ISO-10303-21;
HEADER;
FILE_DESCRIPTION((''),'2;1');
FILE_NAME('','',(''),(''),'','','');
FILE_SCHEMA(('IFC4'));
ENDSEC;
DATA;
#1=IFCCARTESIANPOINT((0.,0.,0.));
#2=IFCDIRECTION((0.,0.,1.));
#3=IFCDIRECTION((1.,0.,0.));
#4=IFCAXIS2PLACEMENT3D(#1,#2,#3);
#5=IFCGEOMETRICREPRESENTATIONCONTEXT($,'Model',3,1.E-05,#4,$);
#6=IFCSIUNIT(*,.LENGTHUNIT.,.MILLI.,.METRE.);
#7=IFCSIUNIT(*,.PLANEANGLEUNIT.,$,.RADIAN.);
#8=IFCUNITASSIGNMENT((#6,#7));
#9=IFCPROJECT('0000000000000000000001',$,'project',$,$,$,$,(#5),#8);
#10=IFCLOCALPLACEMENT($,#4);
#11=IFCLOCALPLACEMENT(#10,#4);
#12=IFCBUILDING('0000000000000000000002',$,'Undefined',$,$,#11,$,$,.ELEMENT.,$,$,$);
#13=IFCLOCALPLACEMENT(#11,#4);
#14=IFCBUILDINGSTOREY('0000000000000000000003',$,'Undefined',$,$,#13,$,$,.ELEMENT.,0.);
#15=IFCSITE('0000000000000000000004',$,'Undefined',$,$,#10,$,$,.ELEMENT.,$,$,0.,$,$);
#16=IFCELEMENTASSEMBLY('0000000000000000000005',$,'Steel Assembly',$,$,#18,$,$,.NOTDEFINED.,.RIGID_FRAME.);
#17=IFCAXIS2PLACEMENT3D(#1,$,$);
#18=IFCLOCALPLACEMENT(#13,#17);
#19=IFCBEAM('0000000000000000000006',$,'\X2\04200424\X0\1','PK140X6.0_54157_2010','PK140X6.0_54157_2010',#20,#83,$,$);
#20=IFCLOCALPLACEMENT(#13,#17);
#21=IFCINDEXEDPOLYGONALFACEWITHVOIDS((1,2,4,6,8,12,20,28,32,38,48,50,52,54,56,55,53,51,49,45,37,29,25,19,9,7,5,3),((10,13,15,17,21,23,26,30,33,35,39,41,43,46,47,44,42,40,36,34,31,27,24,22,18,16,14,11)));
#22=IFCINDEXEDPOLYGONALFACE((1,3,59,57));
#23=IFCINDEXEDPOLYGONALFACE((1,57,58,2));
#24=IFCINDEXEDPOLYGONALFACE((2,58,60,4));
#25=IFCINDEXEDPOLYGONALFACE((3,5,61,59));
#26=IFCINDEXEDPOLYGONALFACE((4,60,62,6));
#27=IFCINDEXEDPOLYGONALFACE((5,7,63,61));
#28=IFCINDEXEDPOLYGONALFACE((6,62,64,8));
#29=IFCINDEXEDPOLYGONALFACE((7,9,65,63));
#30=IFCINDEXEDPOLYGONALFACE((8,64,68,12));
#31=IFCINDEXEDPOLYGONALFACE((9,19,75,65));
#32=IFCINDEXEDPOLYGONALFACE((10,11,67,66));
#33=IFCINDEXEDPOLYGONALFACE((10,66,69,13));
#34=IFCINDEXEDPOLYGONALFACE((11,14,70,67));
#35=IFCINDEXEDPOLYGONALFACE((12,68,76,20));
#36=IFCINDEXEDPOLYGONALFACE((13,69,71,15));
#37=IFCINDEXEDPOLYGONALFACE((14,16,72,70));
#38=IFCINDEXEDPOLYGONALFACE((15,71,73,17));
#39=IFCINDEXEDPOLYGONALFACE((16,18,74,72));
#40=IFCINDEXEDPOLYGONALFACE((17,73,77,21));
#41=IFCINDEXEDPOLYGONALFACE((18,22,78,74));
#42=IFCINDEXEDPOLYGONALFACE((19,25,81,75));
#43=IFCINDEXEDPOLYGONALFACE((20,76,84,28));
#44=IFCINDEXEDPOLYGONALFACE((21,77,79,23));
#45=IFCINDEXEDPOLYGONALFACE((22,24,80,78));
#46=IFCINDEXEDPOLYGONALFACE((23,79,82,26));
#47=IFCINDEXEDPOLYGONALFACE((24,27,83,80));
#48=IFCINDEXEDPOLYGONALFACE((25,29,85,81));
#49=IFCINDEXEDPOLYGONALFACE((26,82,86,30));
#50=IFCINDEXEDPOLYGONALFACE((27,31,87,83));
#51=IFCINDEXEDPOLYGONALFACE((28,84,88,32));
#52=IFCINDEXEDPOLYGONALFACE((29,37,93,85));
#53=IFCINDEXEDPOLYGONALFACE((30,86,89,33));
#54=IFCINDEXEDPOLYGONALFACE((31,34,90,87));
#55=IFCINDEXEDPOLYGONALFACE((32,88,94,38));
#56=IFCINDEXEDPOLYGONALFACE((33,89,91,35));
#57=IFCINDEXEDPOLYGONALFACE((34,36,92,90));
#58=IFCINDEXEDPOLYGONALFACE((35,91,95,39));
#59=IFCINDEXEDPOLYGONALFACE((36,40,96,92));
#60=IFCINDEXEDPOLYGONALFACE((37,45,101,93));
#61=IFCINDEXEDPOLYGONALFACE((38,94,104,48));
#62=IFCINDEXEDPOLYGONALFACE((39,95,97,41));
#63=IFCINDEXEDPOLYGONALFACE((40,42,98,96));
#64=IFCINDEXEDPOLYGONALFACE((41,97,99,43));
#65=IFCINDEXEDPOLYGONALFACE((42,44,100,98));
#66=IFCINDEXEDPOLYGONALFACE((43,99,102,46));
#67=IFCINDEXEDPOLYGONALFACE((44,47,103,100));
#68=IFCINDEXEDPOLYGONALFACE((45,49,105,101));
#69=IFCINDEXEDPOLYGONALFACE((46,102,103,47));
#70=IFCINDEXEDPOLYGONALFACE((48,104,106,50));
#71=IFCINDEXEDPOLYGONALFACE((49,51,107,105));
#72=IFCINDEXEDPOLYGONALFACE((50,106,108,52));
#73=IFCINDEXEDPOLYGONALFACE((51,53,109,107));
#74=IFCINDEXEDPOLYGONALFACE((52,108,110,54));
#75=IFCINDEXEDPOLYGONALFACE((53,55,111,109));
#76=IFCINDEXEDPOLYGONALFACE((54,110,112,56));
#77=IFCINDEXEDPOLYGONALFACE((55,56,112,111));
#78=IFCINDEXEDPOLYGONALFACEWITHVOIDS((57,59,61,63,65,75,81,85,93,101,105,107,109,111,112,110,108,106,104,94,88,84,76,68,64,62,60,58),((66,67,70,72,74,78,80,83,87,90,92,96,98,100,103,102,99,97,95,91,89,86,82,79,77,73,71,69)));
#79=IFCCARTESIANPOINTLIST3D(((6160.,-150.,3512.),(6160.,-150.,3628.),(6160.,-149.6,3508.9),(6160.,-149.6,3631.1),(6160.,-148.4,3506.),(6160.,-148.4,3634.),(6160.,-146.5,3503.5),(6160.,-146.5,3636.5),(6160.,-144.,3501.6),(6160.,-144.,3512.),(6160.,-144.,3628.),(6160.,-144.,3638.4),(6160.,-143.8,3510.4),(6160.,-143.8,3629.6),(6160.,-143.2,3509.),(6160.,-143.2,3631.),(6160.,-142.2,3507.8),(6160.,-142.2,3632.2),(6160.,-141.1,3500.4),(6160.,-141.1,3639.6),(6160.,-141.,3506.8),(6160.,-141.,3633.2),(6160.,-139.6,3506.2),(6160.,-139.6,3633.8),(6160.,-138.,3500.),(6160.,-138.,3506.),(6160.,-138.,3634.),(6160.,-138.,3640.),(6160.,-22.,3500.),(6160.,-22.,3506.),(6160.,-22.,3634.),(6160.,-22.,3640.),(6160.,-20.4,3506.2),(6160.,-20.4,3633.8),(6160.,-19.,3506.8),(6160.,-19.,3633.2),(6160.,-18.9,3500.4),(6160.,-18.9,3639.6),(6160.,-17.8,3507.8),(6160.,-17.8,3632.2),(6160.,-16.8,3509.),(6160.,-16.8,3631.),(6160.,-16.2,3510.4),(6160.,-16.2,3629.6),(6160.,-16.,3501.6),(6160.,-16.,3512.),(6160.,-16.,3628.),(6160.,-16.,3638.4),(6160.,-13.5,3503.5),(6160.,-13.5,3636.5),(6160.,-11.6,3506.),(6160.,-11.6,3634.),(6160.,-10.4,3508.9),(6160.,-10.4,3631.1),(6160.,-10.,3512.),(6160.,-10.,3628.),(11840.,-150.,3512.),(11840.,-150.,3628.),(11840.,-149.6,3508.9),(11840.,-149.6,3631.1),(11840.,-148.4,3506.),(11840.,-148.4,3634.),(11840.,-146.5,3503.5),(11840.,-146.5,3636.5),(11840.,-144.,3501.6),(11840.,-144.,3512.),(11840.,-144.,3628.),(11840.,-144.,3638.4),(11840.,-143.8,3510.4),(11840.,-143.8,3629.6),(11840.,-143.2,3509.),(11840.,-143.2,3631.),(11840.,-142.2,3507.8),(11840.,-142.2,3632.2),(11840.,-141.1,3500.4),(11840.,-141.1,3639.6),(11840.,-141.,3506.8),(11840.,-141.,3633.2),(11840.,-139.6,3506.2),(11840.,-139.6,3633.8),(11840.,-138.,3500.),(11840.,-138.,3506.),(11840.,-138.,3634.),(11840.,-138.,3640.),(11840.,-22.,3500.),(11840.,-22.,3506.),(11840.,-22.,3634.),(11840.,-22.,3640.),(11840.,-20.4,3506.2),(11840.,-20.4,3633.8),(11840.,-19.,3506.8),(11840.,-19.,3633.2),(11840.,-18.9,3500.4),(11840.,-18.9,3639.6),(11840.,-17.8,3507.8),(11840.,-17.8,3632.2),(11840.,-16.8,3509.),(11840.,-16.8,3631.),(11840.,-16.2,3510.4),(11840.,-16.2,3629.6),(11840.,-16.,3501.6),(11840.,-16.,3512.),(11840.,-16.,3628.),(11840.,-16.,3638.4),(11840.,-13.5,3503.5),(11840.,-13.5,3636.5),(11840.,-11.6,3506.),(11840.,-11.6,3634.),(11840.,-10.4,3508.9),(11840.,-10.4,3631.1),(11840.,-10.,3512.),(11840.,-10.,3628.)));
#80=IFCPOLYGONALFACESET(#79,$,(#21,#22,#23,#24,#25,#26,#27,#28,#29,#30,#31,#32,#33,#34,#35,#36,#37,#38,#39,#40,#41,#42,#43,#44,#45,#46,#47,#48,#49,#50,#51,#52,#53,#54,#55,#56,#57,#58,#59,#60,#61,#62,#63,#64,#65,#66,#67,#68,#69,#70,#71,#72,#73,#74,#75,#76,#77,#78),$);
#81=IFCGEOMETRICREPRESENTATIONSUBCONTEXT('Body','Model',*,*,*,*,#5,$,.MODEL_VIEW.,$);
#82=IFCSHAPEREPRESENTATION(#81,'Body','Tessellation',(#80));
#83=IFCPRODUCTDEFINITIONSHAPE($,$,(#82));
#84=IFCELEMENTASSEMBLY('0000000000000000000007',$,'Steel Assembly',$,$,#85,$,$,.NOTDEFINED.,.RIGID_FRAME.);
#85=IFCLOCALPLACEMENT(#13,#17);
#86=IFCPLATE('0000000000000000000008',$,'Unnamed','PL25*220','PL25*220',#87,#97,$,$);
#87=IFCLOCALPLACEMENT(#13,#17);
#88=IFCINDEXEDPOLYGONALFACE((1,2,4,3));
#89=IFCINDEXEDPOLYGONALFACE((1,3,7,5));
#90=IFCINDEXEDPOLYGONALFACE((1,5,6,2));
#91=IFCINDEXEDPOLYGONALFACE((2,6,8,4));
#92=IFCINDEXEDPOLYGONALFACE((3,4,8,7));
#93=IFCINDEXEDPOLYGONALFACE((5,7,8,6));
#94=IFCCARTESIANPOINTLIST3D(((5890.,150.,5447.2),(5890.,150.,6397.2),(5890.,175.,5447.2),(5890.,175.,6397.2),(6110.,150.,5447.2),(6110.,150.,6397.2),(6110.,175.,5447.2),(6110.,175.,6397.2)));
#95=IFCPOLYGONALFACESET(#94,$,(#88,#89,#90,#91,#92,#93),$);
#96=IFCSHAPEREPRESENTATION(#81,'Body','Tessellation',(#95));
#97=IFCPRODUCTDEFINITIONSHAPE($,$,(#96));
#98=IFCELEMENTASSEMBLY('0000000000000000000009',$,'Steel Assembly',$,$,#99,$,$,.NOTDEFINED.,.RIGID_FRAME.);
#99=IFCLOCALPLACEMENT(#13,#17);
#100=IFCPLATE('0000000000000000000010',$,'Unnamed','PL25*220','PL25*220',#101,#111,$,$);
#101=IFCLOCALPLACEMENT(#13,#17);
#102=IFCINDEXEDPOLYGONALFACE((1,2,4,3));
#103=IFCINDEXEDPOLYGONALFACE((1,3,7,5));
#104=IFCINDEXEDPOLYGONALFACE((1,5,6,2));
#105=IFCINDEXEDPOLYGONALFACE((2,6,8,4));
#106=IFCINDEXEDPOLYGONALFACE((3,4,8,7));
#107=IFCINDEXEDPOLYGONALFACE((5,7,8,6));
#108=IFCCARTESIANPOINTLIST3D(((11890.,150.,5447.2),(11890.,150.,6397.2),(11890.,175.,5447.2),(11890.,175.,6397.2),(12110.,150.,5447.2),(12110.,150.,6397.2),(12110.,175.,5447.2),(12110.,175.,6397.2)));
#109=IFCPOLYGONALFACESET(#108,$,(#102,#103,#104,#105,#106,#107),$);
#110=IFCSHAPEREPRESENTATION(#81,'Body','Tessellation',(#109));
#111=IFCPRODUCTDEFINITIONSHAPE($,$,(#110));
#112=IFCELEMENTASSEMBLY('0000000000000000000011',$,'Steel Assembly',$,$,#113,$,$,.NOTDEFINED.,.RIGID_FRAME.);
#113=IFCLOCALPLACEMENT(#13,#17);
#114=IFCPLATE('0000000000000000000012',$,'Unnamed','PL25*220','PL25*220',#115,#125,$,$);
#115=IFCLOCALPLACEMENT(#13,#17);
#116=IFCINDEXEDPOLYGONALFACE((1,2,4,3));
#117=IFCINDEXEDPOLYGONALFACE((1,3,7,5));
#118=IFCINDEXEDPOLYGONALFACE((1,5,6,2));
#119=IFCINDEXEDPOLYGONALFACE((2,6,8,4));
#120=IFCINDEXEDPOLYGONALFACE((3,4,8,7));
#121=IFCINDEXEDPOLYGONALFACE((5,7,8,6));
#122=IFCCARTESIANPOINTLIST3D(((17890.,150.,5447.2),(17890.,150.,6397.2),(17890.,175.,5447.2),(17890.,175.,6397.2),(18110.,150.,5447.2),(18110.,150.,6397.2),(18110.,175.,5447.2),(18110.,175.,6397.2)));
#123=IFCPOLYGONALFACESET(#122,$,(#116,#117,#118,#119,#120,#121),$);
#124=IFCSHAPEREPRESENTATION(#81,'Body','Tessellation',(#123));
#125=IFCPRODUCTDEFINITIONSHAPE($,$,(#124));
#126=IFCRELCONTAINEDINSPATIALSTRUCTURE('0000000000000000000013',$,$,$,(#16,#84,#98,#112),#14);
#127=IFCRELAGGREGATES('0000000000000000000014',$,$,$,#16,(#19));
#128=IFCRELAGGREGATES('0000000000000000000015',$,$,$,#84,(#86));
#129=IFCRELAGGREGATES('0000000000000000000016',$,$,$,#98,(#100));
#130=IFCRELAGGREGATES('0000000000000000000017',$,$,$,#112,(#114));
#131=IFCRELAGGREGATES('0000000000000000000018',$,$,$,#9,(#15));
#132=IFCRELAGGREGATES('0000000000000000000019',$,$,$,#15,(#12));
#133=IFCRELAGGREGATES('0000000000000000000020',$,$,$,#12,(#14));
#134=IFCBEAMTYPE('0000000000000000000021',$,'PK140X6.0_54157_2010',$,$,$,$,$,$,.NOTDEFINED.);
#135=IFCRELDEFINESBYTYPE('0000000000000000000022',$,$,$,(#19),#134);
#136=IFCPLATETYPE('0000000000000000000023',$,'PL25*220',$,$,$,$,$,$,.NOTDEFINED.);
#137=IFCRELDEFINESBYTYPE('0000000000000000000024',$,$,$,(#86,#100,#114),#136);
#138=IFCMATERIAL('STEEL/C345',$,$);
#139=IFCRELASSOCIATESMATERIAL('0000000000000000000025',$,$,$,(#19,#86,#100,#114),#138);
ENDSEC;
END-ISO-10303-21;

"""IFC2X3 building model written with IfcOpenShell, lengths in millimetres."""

from ifc_helpers import new_model, si_unit, frame, origin_with_axes, origin_2d_with_axis, place, context, subcontext, project, spatial, polyline, hollow_rectangle, outline, extrude, material, type_object, element, aggregate, save


model = new_model("IFC2X3")

# Units and contexts
model_context = context("Model", 3, precision=1e-05, world=origin_with_axes())
body_context = subcontext(model_context, "Body", "Model", "MODEL_VIEW")
ifc_project = project(units=[si_unit("LENGTHUNIT", "METRE", prefix="MILLI"), si_unit("PLANEANGLEUNIT", "RADIAN")], contexts=[model_context])

# Site, building, storey
site_placement = place(None, origin_with_axes())
site = spatial("IfcSite", under=ifc_project, at=site_placement, Name="Undefined", CompositionType="ELEMENT", RefElevation=0.0)
building_placement = place(site_placement, origin_with_axes())
building = spatial("IfcBuilding", under=site, at=building_placement, Name="Undefined", CompositionType="ELEMENT")
storey_placement = place(building_placement, origin_with_axes())
storey = spatial("IfcBuildingStorey", under=building, at=storey_placement, Name="Undefined", CompositionType="ELEMENT", Elevation=0.0)

# Shared definitions
ifc_material_1 = material(Name="STEEL/C345")

# Element assembly, beam
assembly_1_placement = place(storey_placement, origin_with_axes())
assembly_1 = element("IfcElementAssembly", 1, at=assembly_1_placement, inside=storey, Name="Steel Assembly", AssemblyPlace="NOTDEFINED", PredefinedType="RIGID_FRAME")
beam_type_1 = type_object("IfcBeamType", Name="PK140X6.0_54157_2010", PredefinedType="NOTDEFINED")
beam_1_placement = place(assembly_1_placement, frame((11840.0, -80.0, 3570.0), z_axis=(0.0, 0.0, 1.0), x_axis=(-1.0, 0.0, 0.0)))
beam_1 = element("IfcBeam", 2, at=beam_1_placement, type_object=beam_type_1, material=ifc_material_1, Name="РФ1", Description="PK140X6.0_54157_2010", ObjectType="PK140X6.0_54157_2010", context=body_context, shape_type="SweptSolid", body=[
    extrude(hollow_rectangle(XDim=140.0, YDim=140.0, WallThickness=6.0, InnerFilletRadius=6.0, OuterFilletRadius=12.0, at=origin_2d_with_axis()), frame((5680.0, 0.0, 0.0), z_axis=(-1.0, 0.0, 0.0), x_axis=(0.0, -1.0, 0.0)), (0.0, 0.0, 1.0), 5680.0),
])
aggregate(assembly_1, [beam_1])

# Element assemblies, plates
assembly_2_placement = place(storey_placement, origin_with_axes())
assembly_2 = element("IfcElementAssembly", 3, at=assembly_2_placement, inside=storey, Name="Steel Assembly", AssemblyPlace="NOTDEFINED", PredefinedType="RIGID_FRAME")
plate_type = type_object("IfcPlateType", Name="PL25*220", PredefinedType="NOTDEFINED")
plate_1_placement = place(assembly_2_placement, frame((6110.0, 162.5, 5447.2), z_axis=(0.0, -1.0, 0.0), x_axis=(0.0, 0.0, 1.0)))
plate_1 = element("IfcPlate", 4, at=plate_1_placement, type_object=plate_type, material=ifc_material_1, Name="Unnamed", Description="PL25*220", ObjectType="PL25*220", context=body_context, shape_type="SweptSolid", body=[
    extrude(outline(polyline([(0.0, 0.0), (950.0, 0.0), (950.0, 220.0), (0.0, 220.0), (0.0, 0.0)])), frame((0.0, 0.0, -12.5), z_axis=(0.0, 0.0, 1.0), x_axis=(1.0, 0.0, 0.0)), (0.0, 0.0, 1.0), 25.0),
])
aggregate(assembly_2, [plate_1])
assembly_3_placement = place(storey_placement, origin_with_axes())
assembly_3 = element("IfcElementAssembly", 5, at=assembly_3_placement, inside=storey, Name="Steel Assembly", AssemblyPlace="NOTDEFINED", PredefinedType="RIGID_FRAME")
plate_2_placement = place(assembly_3_placement, frame((12110.0, 162.5, 5447.2), z_axis=(0.0, -1.0, 0.0), x_axis=(0.0, 0.0, 1.0)))
plate_2 = element("IfcPlate", 6, at=plate_2_placement, type_object=plate_type, material=ifc_material_1, Name="Unnamed", Description="PL25*220", ObjectType="PL25*220", context=body_context, shape_type="SweptSolid", body=[
    extrude(outline(polyline([(0.0, 0.0), (950.0, 0.0), (950.0, 220.0), (0.0, 220.0), (0.0, 0.0)])), frame((0.0, 0.0, -12.5), z_axis=(0.0, 0.0, 1.0), x_axis=(1.0, 0.0, 0.0)), (0.0, 0.0, 1.0), 25.0),
])
aggregate(assembly_3, [plate_2])
assembly_4_placement = place(storey_placement, origin_with_axes())
assembly_4 = element("IfcElementAssembly", 7, at=assembly_4_placement, inside=storey, Name="Steel Assembly", AssemblyPlace="NOTDEFINED", PredefinedType="RIGID_FRAME")
plate_3_placement = place(assembly_4_placement, frame((18110.0, 162.5, 5447.2), z_axis=(0.0, -1.0, 0.0), x_axis=(0.0, 0.0, 1.0)))
plate_3 = element("IfcPlate", 8, at=plate_3_placement, type_object=plate_type, material=ifc_material_1, Name="Unnamed", Description="PL25*220", ObjectType="PL25*220", context=body_context, shape_type="SweptSolid", body=[
    extrude(outline(polyline([(0.0, 0.0), (950.0, 0.0), (950.0, 220.0), (0.0, 220.0), (0.0, 0.0)])), frame((0.0, 0.0, -12.5), z_axis=(0.0, 0.0, 1.0), x_axis=(1.0, 0.0, 0.0)), (0.0, 0.0, 1.0), 25.0),
])
aggregate(assembly_4, [plate_3])

save(model, "model.ifc")
